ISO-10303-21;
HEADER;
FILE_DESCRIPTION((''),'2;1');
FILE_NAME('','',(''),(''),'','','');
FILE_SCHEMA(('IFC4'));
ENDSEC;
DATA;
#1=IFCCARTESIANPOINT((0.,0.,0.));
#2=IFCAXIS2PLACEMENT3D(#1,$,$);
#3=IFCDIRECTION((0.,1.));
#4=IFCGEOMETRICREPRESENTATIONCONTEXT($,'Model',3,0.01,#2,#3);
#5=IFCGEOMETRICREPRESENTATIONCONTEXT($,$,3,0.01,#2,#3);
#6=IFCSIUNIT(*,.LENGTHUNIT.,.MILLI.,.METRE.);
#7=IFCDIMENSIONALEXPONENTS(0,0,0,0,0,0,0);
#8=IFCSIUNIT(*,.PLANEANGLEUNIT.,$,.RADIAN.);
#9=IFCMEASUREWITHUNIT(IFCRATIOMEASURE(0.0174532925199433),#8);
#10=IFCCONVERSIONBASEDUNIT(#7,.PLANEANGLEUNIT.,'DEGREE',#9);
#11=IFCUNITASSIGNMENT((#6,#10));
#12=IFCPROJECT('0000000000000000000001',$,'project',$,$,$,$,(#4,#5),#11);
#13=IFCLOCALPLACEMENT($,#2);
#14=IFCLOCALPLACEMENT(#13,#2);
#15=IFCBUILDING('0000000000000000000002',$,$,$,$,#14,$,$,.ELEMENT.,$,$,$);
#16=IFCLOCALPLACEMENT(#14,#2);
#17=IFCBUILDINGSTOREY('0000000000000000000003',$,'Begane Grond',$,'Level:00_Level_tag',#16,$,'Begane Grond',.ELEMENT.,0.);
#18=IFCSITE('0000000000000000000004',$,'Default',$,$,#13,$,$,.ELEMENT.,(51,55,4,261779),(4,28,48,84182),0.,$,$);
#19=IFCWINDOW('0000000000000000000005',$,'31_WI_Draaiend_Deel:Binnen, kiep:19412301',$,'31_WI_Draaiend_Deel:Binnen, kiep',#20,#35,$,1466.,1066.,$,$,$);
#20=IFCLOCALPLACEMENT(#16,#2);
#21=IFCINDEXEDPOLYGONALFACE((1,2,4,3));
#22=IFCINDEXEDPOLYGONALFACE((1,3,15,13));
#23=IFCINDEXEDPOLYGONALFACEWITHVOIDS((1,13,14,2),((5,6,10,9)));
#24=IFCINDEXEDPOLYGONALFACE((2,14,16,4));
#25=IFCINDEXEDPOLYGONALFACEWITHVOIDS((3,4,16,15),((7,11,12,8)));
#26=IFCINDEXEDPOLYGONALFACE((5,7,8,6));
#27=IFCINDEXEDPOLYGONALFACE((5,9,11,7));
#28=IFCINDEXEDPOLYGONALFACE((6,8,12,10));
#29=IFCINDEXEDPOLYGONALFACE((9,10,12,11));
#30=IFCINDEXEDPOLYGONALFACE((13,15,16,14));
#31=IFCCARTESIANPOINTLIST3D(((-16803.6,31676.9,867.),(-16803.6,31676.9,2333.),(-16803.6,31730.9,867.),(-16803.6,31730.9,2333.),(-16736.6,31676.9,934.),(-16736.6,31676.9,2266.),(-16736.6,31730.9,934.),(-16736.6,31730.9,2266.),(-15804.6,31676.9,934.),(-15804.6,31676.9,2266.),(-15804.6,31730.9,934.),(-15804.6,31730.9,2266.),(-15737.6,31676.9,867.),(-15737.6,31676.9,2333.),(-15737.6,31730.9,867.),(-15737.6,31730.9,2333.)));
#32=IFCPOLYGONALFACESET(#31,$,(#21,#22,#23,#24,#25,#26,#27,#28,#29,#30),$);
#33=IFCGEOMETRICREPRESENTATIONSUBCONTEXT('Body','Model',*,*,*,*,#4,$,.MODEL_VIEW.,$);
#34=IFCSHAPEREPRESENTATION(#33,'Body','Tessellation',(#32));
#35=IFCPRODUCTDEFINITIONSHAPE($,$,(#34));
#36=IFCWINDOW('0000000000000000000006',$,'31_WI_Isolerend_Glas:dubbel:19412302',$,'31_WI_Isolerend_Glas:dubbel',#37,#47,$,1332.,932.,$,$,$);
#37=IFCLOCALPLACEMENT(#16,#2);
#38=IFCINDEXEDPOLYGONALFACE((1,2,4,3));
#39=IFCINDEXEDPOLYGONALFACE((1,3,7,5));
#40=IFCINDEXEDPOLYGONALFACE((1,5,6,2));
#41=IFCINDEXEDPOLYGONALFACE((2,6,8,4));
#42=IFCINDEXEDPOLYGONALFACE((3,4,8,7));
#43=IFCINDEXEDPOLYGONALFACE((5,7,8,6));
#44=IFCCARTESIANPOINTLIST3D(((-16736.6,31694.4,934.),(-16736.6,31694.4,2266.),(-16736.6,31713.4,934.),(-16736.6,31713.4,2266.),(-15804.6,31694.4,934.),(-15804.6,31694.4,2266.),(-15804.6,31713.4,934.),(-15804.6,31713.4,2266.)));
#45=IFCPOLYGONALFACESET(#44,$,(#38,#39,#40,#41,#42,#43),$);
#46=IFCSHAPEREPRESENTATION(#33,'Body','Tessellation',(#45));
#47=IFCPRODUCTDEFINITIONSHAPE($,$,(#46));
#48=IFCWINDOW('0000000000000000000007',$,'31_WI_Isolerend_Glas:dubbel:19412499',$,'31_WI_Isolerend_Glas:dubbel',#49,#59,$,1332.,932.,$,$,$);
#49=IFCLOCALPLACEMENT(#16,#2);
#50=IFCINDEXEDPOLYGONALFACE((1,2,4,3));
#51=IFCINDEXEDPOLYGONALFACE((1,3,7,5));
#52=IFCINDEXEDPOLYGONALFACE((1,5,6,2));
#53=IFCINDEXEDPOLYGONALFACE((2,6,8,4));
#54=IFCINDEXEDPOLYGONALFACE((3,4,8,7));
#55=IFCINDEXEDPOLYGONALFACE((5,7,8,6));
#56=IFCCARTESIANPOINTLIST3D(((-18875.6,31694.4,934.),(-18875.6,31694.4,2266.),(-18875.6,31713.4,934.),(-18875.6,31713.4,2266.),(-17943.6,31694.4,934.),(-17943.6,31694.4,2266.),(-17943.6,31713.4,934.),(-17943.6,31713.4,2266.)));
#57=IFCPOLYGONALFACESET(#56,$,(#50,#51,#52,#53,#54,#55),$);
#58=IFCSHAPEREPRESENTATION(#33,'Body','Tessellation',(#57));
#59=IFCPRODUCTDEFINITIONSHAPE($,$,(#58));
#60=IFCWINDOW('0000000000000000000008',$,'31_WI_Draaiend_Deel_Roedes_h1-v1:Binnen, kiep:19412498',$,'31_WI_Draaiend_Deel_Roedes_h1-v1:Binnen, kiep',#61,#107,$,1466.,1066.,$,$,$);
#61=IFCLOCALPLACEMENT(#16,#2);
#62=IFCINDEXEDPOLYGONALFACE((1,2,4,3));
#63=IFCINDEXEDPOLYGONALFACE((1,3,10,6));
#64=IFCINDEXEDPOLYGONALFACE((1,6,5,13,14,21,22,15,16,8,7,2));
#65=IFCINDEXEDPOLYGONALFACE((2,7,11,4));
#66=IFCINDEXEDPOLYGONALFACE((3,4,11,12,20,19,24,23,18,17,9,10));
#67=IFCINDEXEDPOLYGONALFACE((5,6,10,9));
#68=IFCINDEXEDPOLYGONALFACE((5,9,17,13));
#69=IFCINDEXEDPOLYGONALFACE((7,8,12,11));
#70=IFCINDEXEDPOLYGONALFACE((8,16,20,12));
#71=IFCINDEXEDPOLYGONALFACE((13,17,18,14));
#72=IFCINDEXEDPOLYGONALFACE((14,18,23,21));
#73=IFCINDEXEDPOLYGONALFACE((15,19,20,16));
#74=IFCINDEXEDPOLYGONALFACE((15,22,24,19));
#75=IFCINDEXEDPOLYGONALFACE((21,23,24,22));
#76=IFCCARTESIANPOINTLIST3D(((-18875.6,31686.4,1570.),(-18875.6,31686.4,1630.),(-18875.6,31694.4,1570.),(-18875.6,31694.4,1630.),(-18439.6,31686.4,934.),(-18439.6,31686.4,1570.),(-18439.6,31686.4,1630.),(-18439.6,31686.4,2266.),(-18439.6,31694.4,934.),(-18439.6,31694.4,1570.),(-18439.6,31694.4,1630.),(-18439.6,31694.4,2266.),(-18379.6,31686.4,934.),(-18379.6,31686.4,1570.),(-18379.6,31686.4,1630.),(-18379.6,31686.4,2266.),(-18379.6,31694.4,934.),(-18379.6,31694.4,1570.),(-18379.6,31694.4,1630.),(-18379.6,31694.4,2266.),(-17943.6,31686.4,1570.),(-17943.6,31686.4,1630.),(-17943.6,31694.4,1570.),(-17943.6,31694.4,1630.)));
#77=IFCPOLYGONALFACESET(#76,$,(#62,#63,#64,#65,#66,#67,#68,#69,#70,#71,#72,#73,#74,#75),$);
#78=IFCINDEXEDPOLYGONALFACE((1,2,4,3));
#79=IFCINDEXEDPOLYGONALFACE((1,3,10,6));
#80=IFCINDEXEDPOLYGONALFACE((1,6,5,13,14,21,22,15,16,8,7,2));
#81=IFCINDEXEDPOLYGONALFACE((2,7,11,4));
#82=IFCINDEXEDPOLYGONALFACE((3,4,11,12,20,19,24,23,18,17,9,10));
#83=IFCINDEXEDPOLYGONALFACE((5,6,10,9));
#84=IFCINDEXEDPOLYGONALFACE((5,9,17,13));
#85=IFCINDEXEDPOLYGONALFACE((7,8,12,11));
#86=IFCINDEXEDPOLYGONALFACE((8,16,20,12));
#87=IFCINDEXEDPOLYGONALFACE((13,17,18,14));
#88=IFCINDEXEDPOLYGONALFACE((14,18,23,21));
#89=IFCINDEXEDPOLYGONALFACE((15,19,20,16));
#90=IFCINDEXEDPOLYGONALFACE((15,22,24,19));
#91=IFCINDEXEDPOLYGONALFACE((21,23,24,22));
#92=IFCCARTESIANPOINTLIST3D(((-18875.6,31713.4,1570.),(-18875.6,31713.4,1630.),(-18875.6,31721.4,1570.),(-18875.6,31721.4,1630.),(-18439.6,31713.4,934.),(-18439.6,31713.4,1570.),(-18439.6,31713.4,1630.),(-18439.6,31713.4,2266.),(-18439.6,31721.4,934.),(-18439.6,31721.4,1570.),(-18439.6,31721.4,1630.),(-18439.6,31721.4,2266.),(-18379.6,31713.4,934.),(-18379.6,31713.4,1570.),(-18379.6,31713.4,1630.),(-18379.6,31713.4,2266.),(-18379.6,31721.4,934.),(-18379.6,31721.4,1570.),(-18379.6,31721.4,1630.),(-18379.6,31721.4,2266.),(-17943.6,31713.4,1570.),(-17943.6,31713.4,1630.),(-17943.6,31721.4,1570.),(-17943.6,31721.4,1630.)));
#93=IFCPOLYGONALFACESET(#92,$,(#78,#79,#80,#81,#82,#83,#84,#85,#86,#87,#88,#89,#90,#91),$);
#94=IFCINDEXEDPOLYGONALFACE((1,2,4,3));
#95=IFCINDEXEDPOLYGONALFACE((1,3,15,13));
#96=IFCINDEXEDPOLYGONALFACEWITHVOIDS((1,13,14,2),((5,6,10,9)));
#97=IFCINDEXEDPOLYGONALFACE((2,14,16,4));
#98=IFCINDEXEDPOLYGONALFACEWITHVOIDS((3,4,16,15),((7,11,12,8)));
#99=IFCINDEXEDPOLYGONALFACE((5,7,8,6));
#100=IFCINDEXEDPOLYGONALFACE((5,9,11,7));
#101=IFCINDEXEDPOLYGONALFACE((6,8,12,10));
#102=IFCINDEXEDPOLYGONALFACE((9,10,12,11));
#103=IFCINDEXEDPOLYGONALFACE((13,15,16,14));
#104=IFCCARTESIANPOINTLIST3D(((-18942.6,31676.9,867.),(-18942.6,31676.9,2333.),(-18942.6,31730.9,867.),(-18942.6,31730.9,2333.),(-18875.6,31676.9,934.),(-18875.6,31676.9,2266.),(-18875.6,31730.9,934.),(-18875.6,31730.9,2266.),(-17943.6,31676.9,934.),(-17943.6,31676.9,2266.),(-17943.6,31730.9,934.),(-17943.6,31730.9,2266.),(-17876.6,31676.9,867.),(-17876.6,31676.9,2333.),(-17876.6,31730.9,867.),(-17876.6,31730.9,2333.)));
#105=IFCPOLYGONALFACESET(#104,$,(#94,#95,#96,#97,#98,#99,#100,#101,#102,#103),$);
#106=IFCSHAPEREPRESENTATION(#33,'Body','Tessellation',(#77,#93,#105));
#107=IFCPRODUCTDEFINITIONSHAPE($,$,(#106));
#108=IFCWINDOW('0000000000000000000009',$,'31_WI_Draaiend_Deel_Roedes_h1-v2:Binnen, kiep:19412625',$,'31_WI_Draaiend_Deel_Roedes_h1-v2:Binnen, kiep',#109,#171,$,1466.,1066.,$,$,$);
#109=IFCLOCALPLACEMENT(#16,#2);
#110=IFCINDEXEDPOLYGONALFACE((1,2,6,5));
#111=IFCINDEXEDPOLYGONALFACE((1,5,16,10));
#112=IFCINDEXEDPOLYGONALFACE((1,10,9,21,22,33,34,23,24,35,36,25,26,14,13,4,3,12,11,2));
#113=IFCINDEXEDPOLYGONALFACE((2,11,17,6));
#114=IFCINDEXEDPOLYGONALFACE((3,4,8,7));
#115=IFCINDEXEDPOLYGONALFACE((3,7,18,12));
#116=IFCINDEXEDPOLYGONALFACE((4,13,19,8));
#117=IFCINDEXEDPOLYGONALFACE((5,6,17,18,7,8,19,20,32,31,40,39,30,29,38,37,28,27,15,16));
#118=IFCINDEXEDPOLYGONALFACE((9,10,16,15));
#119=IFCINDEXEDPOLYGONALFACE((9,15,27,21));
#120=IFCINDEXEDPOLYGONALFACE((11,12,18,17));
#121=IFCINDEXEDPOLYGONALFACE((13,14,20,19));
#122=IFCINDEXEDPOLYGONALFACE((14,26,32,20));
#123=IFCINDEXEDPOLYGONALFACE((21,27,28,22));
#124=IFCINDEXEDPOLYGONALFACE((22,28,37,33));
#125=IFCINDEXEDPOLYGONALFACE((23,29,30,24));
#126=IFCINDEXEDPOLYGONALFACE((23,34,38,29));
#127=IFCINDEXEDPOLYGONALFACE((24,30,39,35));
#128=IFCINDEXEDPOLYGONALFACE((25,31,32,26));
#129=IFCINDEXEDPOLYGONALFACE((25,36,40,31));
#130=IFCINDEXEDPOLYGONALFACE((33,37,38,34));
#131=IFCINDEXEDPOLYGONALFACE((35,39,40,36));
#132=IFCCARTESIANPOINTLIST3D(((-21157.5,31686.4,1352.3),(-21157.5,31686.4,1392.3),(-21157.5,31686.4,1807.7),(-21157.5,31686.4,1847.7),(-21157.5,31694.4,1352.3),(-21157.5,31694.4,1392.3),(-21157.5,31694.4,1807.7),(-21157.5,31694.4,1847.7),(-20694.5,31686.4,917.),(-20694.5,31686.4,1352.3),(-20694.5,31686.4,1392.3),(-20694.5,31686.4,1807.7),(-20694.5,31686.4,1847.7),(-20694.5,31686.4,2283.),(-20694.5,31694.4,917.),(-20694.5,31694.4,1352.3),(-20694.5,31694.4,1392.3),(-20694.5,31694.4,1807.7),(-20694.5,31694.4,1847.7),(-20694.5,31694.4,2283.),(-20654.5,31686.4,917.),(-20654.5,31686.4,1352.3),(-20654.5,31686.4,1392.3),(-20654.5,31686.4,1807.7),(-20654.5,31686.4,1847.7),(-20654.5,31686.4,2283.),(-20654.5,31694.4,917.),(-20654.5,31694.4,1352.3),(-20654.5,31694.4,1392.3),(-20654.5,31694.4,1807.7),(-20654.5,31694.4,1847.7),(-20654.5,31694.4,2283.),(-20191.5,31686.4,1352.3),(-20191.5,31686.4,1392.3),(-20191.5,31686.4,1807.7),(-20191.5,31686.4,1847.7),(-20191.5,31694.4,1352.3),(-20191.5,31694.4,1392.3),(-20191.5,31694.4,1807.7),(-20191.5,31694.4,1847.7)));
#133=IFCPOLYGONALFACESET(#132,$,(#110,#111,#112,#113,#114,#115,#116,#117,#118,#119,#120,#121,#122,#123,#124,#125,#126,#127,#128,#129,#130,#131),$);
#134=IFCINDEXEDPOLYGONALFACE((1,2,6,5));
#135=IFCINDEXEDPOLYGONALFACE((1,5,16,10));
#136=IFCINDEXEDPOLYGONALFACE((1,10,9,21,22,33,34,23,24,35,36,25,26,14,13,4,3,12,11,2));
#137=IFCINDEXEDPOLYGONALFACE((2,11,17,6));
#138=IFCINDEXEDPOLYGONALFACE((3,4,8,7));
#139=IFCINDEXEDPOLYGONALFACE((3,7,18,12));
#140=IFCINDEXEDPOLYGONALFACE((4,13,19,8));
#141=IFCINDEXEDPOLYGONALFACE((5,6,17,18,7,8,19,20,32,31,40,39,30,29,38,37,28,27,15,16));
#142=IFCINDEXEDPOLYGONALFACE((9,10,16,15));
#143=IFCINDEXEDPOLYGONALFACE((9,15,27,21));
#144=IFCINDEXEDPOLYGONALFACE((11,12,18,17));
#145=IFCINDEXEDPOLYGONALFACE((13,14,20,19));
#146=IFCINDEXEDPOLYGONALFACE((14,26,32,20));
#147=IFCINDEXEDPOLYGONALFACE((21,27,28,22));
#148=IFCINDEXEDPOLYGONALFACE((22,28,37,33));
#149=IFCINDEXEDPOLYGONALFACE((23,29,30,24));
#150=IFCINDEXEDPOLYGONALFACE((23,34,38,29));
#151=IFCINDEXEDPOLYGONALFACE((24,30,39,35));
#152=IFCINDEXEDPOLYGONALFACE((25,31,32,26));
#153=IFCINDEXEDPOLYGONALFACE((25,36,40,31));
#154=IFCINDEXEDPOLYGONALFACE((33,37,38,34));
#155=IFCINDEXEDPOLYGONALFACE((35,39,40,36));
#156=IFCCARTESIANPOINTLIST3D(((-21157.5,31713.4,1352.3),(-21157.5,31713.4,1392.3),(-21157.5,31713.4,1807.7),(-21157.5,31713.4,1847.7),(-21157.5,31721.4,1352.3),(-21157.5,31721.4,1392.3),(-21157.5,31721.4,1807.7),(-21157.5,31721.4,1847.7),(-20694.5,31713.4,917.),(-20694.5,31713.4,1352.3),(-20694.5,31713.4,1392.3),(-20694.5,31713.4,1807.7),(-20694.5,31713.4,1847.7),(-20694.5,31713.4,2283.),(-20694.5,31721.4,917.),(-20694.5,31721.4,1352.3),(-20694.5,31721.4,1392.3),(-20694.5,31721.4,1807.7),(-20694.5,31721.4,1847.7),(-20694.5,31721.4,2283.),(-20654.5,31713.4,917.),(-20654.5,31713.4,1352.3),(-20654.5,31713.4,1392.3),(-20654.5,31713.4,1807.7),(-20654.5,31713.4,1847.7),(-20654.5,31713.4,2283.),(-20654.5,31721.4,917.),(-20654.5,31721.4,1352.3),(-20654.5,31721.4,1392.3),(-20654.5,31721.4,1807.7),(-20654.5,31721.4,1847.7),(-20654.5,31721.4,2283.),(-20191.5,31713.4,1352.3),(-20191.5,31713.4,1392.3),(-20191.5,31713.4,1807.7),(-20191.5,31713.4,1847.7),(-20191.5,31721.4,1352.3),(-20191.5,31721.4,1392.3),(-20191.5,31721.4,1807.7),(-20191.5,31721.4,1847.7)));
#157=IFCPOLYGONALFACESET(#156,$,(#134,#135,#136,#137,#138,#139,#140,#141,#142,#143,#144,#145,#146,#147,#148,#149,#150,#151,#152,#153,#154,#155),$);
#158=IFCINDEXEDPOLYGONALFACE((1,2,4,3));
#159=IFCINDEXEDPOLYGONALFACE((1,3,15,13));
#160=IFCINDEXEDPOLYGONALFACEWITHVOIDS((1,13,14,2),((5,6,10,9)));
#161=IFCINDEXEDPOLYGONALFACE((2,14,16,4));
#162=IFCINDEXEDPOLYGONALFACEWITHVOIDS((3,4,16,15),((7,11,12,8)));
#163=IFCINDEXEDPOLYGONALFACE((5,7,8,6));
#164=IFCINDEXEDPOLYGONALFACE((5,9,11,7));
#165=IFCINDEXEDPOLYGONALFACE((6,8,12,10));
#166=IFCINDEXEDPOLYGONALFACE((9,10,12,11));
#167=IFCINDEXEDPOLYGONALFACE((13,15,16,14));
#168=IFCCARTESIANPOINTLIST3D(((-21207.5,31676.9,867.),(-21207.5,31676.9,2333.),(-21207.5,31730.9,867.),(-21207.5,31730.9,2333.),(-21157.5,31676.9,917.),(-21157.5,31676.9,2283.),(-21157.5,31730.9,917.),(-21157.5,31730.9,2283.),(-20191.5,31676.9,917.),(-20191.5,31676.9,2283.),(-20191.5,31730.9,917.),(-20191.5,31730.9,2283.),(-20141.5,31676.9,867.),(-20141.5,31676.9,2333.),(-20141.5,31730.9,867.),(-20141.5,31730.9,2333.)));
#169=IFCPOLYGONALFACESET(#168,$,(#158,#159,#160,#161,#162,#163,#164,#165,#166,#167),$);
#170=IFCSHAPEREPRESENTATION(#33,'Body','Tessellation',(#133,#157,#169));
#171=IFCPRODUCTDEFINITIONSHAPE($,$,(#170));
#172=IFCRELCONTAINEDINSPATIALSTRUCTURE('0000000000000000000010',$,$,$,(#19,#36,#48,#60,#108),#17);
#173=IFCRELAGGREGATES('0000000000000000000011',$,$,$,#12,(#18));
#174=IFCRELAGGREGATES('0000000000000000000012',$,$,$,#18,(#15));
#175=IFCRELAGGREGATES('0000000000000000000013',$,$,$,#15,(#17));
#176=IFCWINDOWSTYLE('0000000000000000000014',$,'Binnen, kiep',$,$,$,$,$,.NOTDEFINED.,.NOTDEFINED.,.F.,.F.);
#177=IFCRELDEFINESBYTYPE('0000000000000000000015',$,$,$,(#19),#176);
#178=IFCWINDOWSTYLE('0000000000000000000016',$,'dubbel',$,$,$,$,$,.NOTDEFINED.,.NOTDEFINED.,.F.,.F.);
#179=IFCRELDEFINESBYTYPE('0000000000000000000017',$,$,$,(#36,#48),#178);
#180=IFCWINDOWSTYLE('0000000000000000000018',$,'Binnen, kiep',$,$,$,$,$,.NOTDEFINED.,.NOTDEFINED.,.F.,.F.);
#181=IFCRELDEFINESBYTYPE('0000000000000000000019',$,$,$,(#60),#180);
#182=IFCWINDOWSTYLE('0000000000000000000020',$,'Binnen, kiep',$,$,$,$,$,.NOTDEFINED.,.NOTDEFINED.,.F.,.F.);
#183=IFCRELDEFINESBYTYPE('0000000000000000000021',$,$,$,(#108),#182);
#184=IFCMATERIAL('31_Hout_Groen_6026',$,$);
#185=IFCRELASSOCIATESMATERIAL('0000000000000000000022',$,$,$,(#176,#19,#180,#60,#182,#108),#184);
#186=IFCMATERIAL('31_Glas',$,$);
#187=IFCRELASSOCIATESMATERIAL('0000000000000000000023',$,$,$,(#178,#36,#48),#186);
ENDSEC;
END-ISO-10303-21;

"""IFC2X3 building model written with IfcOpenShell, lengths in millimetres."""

from ifc_helpers import new_model, entity, si_unit, converted_unit, direction, frame, frame_2d, origin, place, context, subcontext, project, spatial, polyline, rectangle, outline, extrude, source, transform, mapped, material, type_object, type_shapes, element, save


model = new_model("IFC2X3")

# Units and contexts
model_context = context("Model", 3, precision=0.01, world=origin(), true_north=direction((0.0, 1.0)))
context_of_model = context(None, 3, precision=0.01, world=origin(), true_north=direction((0.0, 1.0)))
body_context = subcontext(model_context, "Body", "Model", "MODEL_VIEW")
ifc_project = project(units=[si_unit("LENGTHUNIT", "METRE", prefix="MILLI"), converted_unit("PLANEANGLEUNIT", "DEGREE", entity("IfcRatioMeasure", 0.0174532925199433), si_unit("PLANEANGLEUNIT", "RADIAN"), dimensions=[0, 0, 0, 0, 0, 0, 0])], contexts=[model_context, context_of_model])

# Site, building, storey
site_placement = place(None, origin())
site = spatial("IfcSite", under=ifc_project, at=site_placement, Name="Default", CompositionType="ELEMENT", RefLatitude=(51, 55, 4, 261779), RefLongitude=(4, 28, 48, 84182), RefElevation=0.0)
building_placement = place(site_placement, origin())
building = spatial("IfcBuilding", under=site, at=building_placement, CompositionType="ELEMENT")
storey_placement = place(building_placement, origin())
storey = spatial("IfcBuildingStorey", under=building, at=storey_placement, Name="Begane Grond", ObjectType="Level:00_Level_tag", LongName="Begane Grond", CompositionType="ELEMENT", Elevation=0.0)

# Windows
ifc_material_1 = material(Name="31_Hout_Groen_6026")
window_style_1 = type_object("IfcWindowStyle", Name="Binnen, kiep", ConstructionType="NOTDEFINED", OperationType="NOTDEFINED", ParameterTakesPrecedence=False, Sizeable=False, material=ifc_material_1)
shared_shape_1 = source(origin(), body_context, "Body", "SweptSolid", [
    extrude(outline(polyline([(-733.0, -533.0), (733.0, -533.0), (733.0, 533.0), (-733.0, 533.0), (-733.0, -533.0)]), holes=[polyline([(666.0, -466.0), (-666.0, -466.0), (-666.0, 466.0), (666.0, 466.0), (666.0, -466.0)])]), frame((0.0, -47.0, 733.0), z_axis=(0.0, 1.0, 0.0), x_axis=(0.0, 0.0, -1.0)), (0.0, 0.0, 1.0), 54.0),
])
type_shapes(window_style_1, [shared_shape_1])
window_1_placement = place(storey_placement, frame((-16270.6, 31683.9, 867.0), z_axis=(0.0, 0.0, 1.0), x_axis=(-1.0, 0.0, 0.0)))
element("IfcWindow", 1, at=window_1_placement, inside=storey, type_object=window_style_1, material=ifc_material_1, Name="31_WI_Draaiend_Deel:Binnen, kiep:19412301", ObjectType="31_WI_Draaiend_Deel:Binnen, kiep", OverallHeight=1466.0, OverallWidth=1066.0, context=body_context, shape_type="MappedRepresentation", body=[
    mapped(shared_shape_1, transform((0.0, 0.0, 0.0), scale=1.0)),
])
ifc_material_2 = material(Name="31_Glas")
window_style_2 = type_object("IfcWindowStyle", Name="dubbel", ConstructionType="NOTDEFINED", OperationType="NOTDEFINED", ParameterTakesPrecedence=False, Sizeable=False, material=ifc_material_2)
shared_shape_2 = source(origin(), body_context, "Body", "SweptSolid", [
    extrude(rectangle(XDim=19.0, YDim=932.0, at=frame_2d((0.0, 0.0), x_axis=(1.0, 0.0))), frame((0.0, -28.5, 0.0), z_axis=(0.0, 0.0, 1.0), x_axis=(0.0, 1.0, 0.0)), (0.0, 0.0, 1.0), 1332.0),
])
type_shapes(window_style_2, [shared_shape_2])
for number, where, z_axis, x_axis, name in (
    (2, (-16270.6, 31675.4, 934.0), (0.0, 0.0, 1.0), (-1.0, 0.0, 0.0), "31_WI_Isolerend_Glas:dubbel:19412302"),
    (3, (-18409.6, 31675.4, 934.0), (0.0, 0.0, 1.0), (-1.0, 0.0, 0.0), "31_WI_Isolerend_Glas:dubbel:19412499"),
):
    element("IfcWindow", number, at=place(storey_placement, frame(where, z_axis=z_axis, x_axis=x_axis)), inside=storey, type_object=window_style_2, material=ifc_material_2, Name=name, ObjectType="31_WI_Isolerend_Glas:dubbel", OverallHeight=1332.0, OverallWidth=932.0, context=body_context, shape_type="MappedRepresentation", body=[
        mapped(shared_shape_2, transform((0.0, 0.0, 0.0), scale=1.0)),
    ])
window_style_3 = type_object("IfcWindowStyle", Name="Binnen, kiep", ConstructionType="NOTDEFINED", OperationType="NOTDEFINED", ParameterTakesPrecedence=False, Sizeable=False, material=ifc_material_1)
shared_shape_3 = source(origin(), body_context, "Body", "SweptSolid", [
    extrude(outline(polyline([(-666.0, 30.0), (-666.0, -30.0), (-30.0, -30.0), (-30.0, -466.0), (30.0, -466.0), (30.0, -30.0), (666.0, -30.0), (666.0, 30.0), (30.0, 30.0), (30.0, 466.0), (-30.0, 466.0), (-30.0, 30.0), (-666.0, 30.0)])), frame((0.0, -10.5, 733.0), z_axis=(0.0, -1.0, 0.0), x_axis=(0.0, 0.0, -1.0)), (0.0, 0.0, -1.0), 8.0),
    extrude(outline(polyline([(-666.0, 30.0), (-666.0, -30.0), (-30.0, -30.0), (-30.0, -466.0), (30.0, -466.0), (30.0, -30.0), (666.0, -30.0), (666.0, 30.0), (30.0, 30.0), (30.0, 466.0), (-30.0, 466.0), (-30.0, 30.0), (-666.0, 30.0)])), frame((0.0, -37.5, 733.0), z_axis=(0.0, -1.0, 0.0), x_axis=(0.0, 0.0, -1.0)), (0.0, 0.0, -1.0), 8.0),
    extrude(outline(polyline([(-733.0, -533.0), (733.0, -533.0), (733.0, 533.0), (-733.0, 533.0), (-733.0, -533.0)]), holes=[polyline([(666.0, -466.0), (-666.0, -466.0), (-666.0, 466.0), (666.0, 466.0), (666.0, -466.0)])]), frame((0.0, -47.0, 733.0), z_axis=(0.0, 1.0, 0.0), x_axis=(0.0, 0.0, -1.0)), (0.0, 0.0, 1.0), 54.0),
])
type_shapes(window_style_3, [shared_shape_3])
window_2_placement = place(storey_placement, frame((-18409.6, 31683.9, 867.0), z_axis=(0.0, 0.0, 1.0), x_axis=(-1.0, 0.0, 0.0)))
element("IfcWindow", 4, at=window_2_placement, inside=storey, type_object=window_style_3, material=ifc_material_1, Name="31_WI_Draaiend_Deel_Roedes_h1-v1:Binnen, kiep:19412498", ObjectType="31_WI_Draaiend_Deel_Roedes_h1-v1:Binnen, kiep", OverallHeight=1466.0, OverallWidth=1066.0, context=body_context, shape_type="MappedRepresentation", body=[
    mapped(shared_shape_3, transform((0.0, 0.0, 0.0), scale=1.0)),
])
window_style_4 = type_object("IfcWindowStyle", Name="Binnen, kiep", ConstructionType="NOTDEFINED", OperationType="NOTDEFINED", ParameterTakesPrecedence=False, Sizeable=False, material=ifc_material_1)
shared_shape_4 = source(origin(), body_context, "Body", "SweptSolid", [
    extrude(outline(polyline([(-683.0, 20.0), (-683.0, -20.0), (-247.7, -20.0), (-247.7, -483.0), (-207.7, -483.0), (-207.7, -20.0), (207.7, -20.0), (207.7, -483.0), (247.7, -483.0), (247.7, -20.0), (683.0, -20.0), (683.0, 20.0), (247.7, 20.0), (247.7, 483.0), (207.7, 483.0), (207.7, 20.0), (-207.7, 20.0), (-207.7, 483.0), (-247.7, 483.0), (-247.7, 20.0), (-683.0, 20.0)])), frame((0.0, -10.5, 733.0), z_axis=(0.0, -1.0, 0.0), x_axis=(0.0, 0.0, -1.0)), (0.0, 0.0, -1.0), 8.0),
    extrude(outline(polyline([(-683.0, 20.0), (-683.0, -20.0), (-247.7, -20.0), (-247.7, -483.0), (-207.7, -483.0), (-207.7, -20.0), (207.7, -20.0), (207.7, -483.0), (247.7, -483.0), (247.7, -20.0), (683.0, -20.0), (683.0, 20.0), (247.7, 20.0), (247.7, 483.0), (207.7, 483.0), (207.7, 20.0), (-207.7, 20.0), (-207.7, 483.0), (-247.7, 483.0), (-247.7, 20.0), (-683.0, 20.0)])), frame((0.0, -37.5, 733.0), z_axis=(0.0, -1.0, 0.0), x_axis=(0.0, 0.0, -1.0)), (0.0, 0.0, -1.0), 8.0),
    extrude(outline(polyline([(-733.0, -533.0), (733.0, -533.0), (733.0, 533.0), (-733.0, 533.0), (-733.0, -533.0)]), holes=[polyline([(683.0, -483.0), (-683.0, -483.0), (-683.0, 483.0), (683.0, 483.0), (683.0, -483.0)])]), frame((0.0, -47.0, 733.0), z_axis=(0.0, 1.0, 0.0), x_axis=(0.0, 0.0, -1.0)), (0.0, 0.0, 1.0), 54.0),
])
type_shapes(window_style_4, [shared_shape_4])
window_3_placement = place(storey_placement, frame((-20674.5, 31683.9, 867.0), z_axis=(0.0, 0.0, 1.0), x_axis=(-1.0, 0.0, 0.0)))
element("IfcWindow", 5, at=window_3_placement, inside=storey, type_object=window_style_4, material=ifc_material_1, Name="31_WI_Draaiend_Deel_Roedes_h1-v2:Binnen, kiep:19412625", ObjectType="31_WI_Draaiend_Deel_Roedes_h1-v2:Binnen, kiep", OverallHeight=1466.0, OverallWidth=1066.0, context=body_context, shape_type="MappedRepresentation", body=[
    mapped(shared_shape_4, transform((0.0, 0.0, 0.0), scale=1.0)),
])

save(model, "model.ifc")
